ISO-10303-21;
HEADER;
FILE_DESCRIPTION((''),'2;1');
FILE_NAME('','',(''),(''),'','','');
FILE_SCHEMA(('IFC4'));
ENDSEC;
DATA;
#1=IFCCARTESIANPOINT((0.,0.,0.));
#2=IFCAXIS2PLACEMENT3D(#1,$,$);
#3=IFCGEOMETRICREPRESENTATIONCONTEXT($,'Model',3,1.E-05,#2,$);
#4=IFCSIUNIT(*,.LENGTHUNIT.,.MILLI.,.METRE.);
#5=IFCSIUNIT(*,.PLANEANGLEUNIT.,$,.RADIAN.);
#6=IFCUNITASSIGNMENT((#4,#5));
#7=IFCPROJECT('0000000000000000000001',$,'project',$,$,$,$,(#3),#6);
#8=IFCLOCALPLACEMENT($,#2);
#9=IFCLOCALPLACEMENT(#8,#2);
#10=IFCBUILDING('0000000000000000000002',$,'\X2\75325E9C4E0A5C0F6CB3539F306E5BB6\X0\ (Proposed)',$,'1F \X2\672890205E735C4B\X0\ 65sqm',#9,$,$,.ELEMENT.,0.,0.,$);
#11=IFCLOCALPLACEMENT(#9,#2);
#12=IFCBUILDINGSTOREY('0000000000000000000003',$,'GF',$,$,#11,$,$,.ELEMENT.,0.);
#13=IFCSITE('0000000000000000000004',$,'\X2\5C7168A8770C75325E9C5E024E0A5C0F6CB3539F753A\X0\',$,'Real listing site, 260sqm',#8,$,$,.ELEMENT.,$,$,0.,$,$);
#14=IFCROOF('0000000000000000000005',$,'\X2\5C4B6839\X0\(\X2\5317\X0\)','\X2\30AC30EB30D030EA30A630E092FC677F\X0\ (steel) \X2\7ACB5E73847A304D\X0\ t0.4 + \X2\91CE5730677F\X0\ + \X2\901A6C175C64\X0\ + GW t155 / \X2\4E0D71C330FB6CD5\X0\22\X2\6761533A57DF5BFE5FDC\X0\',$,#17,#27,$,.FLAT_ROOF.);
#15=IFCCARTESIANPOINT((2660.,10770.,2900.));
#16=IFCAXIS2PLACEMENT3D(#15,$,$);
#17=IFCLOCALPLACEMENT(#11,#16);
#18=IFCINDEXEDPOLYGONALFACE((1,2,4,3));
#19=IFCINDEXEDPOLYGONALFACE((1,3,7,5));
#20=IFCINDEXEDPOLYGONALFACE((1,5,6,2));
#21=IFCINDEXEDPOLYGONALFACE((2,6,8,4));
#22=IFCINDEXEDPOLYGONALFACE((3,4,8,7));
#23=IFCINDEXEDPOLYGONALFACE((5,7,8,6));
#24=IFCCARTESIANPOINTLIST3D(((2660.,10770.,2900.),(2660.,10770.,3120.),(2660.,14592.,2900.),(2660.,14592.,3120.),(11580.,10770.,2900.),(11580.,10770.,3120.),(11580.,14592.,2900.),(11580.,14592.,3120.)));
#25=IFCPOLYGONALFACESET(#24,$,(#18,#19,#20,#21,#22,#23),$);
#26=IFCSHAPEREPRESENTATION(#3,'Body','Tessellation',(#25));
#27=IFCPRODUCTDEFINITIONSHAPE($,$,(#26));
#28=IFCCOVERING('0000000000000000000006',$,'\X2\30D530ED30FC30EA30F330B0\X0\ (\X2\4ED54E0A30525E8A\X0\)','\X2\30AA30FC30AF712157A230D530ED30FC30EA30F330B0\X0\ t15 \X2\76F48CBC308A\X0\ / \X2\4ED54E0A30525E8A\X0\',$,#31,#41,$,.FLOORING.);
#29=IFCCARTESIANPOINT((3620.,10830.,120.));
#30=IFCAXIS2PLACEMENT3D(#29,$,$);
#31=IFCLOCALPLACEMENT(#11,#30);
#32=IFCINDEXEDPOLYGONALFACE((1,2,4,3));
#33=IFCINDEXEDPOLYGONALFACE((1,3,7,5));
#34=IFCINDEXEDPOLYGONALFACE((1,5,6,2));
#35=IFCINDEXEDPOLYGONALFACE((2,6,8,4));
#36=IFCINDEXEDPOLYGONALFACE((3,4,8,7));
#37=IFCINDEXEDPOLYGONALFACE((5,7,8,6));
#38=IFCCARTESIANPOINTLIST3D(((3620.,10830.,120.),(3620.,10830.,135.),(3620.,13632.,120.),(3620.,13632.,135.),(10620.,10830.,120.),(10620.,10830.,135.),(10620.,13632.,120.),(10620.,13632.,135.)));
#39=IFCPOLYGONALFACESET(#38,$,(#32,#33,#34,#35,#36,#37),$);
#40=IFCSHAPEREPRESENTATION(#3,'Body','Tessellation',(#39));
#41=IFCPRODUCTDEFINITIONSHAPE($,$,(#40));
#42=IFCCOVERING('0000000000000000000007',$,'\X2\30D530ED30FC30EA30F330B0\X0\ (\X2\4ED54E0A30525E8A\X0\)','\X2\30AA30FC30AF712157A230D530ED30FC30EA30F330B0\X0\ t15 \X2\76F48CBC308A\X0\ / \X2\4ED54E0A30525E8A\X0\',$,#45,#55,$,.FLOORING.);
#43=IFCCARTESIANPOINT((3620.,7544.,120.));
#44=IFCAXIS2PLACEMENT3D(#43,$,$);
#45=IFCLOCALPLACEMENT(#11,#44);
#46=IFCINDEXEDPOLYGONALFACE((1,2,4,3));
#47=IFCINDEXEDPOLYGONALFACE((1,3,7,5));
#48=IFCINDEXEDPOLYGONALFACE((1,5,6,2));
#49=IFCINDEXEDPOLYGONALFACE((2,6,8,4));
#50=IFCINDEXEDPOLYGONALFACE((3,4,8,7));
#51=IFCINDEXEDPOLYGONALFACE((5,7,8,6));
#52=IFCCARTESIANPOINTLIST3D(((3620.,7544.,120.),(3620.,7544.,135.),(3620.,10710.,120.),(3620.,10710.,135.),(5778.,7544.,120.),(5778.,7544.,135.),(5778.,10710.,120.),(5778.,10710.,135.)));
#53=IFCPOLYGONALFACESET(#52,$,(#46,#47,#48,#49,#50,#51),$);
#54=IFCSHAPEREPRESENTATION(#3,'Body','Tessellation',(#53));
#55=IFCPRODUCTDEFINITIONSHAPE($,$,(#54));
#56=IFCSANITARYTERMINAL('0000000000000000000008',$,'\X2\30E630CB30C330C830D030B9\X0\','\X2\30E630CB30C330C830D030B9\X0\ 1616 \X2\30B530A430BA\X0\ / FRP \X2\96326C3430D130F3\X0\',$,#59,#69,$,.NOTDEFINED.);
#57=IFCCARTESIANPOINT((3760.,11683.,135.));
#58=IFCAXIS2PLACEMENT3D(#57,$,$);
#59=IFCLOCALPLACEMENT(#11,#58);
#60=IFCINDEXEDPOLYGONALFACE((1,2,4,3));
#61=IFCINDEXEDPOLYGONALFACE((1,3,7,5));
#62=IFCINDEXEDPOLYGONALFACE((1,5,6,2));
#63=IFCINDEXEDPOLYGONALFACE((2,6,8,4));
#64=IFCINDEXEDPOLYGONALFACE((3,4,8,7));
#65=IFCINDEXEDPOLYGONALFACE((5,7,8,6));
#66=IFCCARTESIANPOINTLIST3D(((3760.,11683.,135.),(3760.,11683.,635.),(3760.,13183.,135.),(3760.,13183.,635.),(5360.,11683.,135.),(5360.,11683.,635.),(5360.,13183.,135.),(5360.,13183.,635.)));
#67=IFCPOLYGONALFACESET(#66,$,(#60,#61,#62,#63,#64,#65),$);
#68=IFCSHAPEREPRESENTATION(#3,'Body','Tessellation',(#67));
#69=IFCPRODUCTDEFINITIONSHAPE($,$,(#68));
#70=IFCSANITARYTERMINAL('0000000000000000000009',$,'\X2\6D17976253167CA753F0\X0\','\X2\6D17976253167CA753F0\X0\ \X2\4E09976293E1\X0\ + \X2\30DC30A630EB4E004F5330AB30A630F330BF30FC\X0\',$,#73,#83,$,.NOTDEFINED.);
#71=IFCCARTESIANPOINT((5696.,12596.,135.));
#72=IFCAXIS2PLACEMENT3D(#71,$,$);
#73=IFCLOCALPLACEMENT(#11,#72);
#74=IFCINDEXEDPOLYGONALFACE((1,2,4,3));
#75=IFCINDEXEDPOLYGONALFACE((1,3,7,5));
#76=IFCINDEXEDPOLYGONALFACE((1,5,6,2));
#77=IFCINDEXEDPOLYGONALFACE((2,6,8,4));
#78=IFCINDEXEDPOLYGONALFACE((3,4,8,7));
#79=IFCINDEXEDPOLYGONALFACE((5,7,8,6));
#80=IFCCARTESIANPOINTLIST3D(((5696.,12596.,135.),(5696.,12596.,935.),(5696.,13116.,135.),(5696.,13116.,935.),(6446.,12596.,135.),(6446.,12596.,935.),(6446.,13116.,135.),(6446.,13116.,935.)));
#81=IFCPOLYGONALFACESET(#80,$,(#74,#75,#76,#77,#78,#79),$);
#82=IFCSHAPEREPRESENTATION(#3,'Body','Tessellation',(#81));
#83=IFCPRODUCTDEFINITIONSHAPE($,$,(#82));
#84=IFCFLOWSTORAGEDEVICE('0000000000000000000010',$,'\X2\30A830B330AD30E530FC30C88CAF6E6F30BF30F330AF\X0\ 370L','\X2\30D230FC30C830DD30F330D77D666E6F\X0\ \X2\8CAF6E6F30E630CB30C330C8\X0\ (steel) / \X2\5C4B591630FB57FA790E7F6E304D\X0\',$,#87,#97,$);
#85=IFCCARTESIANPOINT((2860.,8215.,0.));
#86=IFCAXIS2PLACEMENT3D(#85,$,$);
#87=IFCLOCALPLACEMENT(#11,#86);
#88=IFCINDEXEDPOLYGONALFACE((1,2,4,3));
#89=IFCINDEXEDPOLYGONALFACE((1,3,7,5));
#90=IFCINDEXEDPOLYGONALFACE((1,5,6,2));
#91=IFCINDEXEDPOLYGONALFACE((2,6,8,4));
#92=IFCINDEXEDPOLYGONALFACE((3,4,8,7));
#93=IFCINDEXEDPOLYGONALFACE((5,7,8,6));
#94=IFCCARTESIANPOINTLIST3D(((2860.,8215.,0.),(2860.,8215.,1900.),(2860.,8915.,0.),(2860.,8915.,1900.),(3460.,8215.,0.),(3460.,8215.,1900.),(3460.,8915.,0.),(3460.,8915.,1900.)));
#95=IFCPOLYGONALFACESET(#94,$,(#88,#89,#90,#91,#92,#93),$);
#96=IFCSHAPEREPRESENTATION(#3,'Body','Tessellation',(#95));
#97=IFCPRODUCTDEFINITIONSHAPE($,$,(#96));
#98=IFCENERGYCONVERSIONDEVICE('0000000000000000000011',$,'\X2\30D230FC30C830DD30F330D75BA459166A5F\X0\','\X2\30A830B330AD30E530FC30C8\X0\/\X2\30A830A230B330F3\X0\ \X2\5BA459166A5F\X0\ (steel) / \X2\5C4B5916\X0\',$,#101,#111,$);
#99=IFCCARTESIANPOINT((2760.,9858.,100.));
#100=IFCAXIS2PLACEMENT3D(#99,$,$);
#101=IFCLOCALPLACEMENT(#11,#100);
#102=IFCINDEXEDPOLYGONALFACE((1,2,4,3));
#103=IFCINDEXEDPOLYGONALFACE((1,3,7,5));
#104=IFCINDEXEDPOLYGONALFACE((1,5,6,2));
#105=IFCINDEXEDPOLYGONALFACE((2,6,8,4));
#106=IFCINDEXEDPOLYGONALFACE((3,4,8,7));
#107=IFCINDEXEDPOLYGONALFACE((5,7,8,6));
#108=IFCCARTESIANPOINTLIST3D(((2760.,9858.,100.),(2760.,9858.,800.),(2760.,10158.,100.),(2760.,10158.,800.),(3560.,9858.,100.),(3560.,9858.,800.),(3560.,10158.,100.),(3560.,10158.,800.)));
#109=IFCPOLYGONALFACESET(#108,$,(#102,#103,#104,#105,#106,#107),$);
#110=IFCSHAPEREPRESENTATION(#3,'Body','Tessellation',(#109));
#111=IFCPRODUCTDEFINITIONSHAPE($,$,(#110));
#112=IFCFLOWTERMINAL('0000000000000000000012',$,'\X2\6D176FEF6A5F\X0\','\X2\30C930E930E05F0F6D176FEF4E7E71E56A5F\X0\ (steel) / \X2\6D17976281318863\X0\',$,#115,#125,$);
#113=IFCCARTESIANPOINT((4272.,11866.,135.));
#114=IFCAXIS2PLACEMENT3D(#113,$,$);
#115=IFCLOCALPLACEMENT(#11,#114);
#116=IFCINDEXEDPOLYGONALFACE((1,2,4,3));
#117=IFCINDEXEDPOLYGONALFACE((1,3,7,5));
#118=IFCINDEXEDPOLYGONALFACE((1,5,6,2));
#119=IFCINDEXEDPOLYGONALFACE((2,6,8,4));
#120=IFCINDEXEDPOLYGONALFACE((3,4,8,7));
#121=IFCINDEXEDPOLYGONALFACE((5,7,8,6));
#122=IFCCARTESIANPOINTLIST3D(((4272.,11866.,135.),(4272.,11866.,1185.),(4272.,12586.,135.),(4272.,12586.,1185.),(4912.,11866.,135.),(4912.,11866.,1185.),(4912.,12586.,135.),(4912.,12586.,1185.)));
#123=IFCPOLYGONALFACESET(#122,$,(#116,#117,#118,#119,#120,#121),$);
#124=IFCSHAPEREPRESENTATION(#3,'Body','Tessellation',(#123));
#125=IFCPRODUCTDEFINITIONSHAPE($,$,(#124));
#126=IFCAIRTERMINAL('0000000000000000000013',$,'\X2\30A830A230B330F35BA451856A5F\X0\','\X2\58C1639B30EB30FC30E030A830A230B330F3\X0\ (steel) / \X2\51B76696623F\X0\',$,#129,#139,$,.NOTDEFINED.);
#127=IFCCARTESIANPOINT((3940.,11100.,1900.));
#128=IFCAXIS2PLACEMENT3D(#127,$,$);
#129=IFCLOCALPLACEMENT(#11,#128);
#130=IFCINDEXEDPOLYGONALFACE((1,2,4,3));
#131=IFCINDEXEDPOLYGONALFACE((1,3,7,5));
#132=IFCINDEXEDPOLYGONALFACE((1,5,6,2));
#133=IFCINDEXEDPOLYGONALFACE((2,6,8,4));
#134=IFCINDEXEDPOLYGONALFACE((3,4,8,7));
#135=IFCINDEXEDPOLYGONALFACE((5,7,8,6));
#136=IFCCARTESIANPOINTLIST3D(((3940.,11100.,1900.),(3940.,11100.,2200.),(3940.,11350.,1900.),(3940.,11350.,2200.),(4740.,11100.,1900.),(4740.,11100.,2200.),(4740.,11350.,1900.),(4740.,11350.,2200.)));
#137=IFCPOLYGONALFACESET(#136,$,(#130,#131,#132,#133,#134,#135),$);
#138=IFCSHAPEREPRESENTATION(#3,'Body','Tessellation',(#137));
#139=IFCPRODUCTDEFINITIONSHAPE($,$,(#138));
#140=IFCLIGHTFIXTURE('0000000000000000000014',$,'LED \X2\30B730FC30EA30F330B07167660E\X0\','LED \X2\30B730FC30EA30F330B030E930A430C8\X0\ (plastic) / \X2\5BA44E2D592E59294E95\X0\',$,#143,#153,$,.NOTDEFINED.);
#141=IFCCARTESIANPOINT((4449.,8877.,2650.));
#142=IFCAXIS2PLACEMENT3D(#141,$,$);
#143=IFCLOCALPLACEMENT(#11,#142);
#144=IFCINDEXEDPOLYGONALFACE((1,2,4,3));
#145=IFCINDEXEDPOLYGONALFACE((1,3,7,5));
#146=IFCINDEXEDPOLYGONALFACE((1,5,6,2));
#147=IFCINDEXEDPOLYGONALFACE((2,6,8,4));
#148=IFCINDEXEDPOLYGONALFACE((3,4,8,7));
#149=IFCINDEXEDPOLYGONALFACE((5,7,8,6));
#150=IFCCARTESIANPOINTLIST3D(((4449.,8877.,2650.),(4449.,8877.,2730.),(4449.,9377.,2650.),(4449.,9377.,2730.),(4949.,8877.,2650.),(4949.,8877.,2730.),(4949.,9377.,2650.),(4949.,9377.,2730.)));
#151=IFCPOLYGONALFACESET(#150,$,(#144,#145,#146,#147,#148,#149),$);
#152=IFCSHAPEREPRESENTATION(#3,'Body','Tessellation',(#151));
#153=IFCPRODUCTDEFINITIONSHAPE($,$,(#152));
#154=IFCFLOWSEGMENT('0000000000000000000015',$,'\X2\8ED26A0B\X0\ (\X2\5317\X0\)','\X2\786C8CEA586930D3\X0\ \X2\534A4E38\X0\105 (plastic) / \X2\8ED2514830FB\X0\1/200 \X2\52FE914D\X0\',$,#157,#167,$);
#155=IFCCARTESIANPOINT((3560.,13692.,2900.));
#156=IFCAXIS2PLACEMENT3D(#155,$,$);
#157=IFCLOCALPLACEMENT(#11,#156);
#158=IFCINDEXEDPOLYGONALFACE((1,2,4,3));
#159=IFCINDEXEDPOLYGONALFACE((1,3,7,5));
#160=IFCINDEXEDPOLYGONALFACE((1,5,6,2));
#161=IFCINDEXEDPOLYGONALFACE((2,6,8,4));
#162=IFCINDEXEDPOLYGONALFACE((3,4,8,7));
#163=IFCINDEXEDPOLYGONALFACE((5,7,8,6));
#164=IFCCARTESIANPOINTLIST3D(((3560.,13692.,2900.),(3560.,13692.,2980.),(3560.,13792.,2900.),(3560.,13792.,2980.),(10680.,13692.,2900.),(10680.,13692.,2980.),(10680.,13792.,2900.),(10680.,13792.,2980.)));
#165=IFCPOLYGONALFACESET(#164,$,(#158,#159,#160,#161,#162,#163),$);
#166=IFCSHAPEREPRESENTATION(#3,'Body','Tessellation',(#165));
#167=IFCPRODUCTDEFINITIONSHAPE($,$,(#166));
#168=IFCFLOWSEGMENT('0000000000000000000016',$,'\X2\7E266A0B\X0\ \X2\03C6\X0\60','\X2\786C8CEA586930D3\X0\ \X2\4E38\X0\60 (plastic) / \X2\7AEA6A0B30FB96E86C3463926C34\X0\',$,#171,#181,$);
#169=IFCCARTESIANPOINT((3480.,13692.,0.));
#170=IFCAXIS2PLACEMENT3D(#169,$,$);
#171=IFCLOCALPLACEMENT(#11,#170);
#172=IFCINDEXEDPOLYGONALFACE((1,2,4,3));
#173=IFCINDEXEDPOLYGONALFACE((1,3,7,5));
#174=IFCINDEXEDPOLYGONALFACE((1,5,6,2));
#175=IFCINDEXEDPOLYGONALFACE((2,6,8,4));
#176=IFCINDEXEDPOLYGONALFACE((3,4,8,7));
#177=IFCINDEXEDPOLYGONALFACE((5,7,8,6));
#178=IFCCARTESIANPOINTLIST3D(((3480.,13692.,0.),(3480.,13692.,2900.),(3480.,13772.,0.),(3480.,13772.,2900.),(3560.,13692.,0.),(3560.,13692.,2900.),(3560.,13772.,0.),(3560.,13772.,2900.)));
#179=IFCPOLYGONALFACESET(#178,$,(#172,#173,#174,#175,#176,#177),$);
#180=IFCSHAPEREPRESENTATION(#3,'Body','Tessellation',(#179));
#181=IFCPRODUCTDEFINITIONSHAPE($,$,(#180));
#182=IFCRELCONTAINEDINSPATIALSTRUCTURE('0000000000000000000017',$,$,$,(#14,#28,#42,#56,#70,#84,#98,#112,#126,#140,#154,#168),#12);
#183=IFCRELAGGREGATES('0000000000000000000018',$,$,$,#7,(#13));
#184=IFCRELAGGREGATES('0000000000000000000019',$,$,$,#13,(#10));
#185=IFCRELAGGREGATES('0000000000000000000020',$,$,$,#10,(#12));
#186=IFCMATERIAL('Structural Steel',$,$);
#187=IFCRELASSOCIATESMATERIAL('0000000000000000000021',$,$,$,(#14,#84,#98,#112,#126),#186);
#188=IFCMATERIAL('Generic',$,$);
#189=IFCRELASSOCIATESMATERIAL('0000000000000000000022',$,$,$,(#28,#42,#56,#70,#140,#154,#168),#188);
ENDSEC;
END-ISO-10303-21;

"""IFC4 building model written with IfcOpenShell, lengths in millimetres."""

from ifc_helpers import new_model, si_unit, frame, frame_2d, origin, place, context, project, spatial, rectangle, extrude, material, element, save


model = new_model("IFC4")

# Units and contexts
model_context = context("Model", 3, precision=1e-05, world=origin())
ifc_project = project(units=[si_unit("LENGTHUNIT", "METRE", prefix="MILLI"), si_unit("PLANEANGLEUNIT", "RADIAN")], contexts=[model_context])

# Site, building, storey
site_placement = place(None, origin())
site = spatial("IfcSite", under=ifc_project, at=site_placement, Name="山梨県甲府市上小河原町", ObjectType="Real listing site, 260sqm", CompositionType="ELEMENT", RefElevation=0.0)
building_placement = place(site_placement, origin())
building = spatial("IfcBuilding", under=site, at=building_placement, Name="甲府上小河原の家 (Proposed)", ObjectType="1F 木造平屋 65sqm", CompositionType="ELEMENT", ElevationOfRefHeight=0.0, ElevationOfTerrain=0.0)
storey_placement = place(building_placement, origin())
storey = spatial("IfcBuildingStorey", under=building, at=storey_placement, Name="GF", CompositionType="ELEMENT", Elevation=0.0)

# Roof
ifc_material_1 = material(Name="Structural Steel")
roof_placement = place(storey_placement, frame((2660.0, 10770.0, 2900.0)))
element("IfcRoof", 1, at=roof_placement, inside=storey, material=ifc_material_1, Name="屋根(北)", Description="ガルバリウム鋼板 (steel) 立平葺き t0.4 + 野地板 + 通気層 + GW t155 / 不燃・法22条区域対応", PredefinedType="FLAT_ROOF", context=model_context, shape_type="SweptSolid", body=[
    extrude(rectangle(XDim=8920.0, YDim=3822.0, at=frame_2d((4460.0, 1911.0))), frame((2660.0, 10770.0, 2900.0)), (0.0, 0.0, 1.0), 220.0),
])

# Coverings
ifc_material_2 = material(Name="Generic")
covering_1_placement = place(storey_placement, frame((3620.0, 10830.0, 120.0)))
element("IfcCovering", 2, at=covering_1_placement, inside=storey, material=ifc_material_2, Name="フローリング (仕上げ床)", Description="オーク無垢フローリング t15 直貼り / 仕上げ床", PredefinedType="FLOORING", context=model_context, shape_type="SweptSolid", body=[
    extrude(rectangle(XDim=7000.0, YDim=2802.0, at=frame_2d((3500.0, 1401.0))), frame((3620.0, 10830.0, 120.0)), (0.0, 0.0, 1.0), 15.0),
])
covering_2_placement = place(storey_placement, frame((3620.0, 7544.0, 120.0)))
element("IfcCovering", 3, at=covering_2_placement, inside=storey, material=ifc_material_2, Name="フローリング (仕上げ床)", Description="オーク無垢フローリング t15 直貼り / 仕上げ床", PredefinedType="FLOORING", context=model_context, shape_type="SweptSolid", body=[
    extrude(rectangle(XDim=2158.0, YDim=3166.0, at=frame_2d((1079.0, 1583.0))), frame((3620.0, 7544.0, 120.0)), (0.0, 0.0, 1.0), 15.0),
])

# Sanitary terminals
sanitary_terminal_1_placement = place(storey_placement, frame((3760.0, 11683.0, 135.0)))
element("IfcSanitaryTerminal", 4, at=sanitary_terminal_1_placement, inside=storey, material=ifc_material_2, Name="ユニットバス", Description="ユニットバス 1616 サイズ / FRP 防水パン", PredefinedType="NOTDEFINED", context=model_context, shape_type="SweptSolid", body=[
    extrude(rectangle(XDim=1600.0, YDim=1500.0, at=frame_2d((800.0, 750.0))), frame((3760.0, 11683.0, 135.0)), (0.0, 0.0, 1.0), 500.0),
])
sanitary_terminal_2_placement = place(storey_placement, frame((5696.0, 12596.0, 135.0)))
element("IfcSanitaryTerminal", 5, at=sanitary_terminal_2_placement, inside=storey, material=ifc_material_2, Name="洗面化粧台", Description="洗面化粧台 三面鏡 + ボウル一体カウンター", PredefinedType="NOTDEFINED", context=model_context, shape_type="SweptSolid", body=[
    extrude(rectangle(XDim=750.0, YDim=520.0, at=frame_2d((375.0, 260.0))), frame((5696.0, 12596.0, 135.0)), (0.0, 0.0, 1.0), 800.0),
])

# Flow storage device
flow_storage_device_placement = place(storey_placement, frame((2860.0, 8215.0, 0.0)))
element("IfcFlowStorageDevice", 6, at=flow_storage_device_placement, inside=storey, material=ifc_material_1, Name="エコキュート貯湯タンク 370L", Description="ヒートポンプ給湯 貯湯ユニット (steel) / 屋外・基礎置き", context=model_context, shape_type="SweptSolid", body=[
    extrude(rectangle(XDim=600.0, YDim=700.0, at=frame_2d((300.0, 350.0))), frame((2860.0, 8215.0, 0.0)), (0.0, 0.0, 1.0), 1900.0),
])

# Energy conversion device
energy_conversion_device_placement = place(storey_placement, frame((2760.0, 9858.0, 100.0)))
element("IfcEnergyConversionDevice", 7, at=energy_conversion_device_placement, inside=storey, material=ifc_material_1, Name="ヒートポンプ室外機", Description="エコキュート/エアコン 室外機 (steel) / 屋外", context=model_context, shape_type="SweptSolid", body=[
    extrude(rectangle(XDim=800.0, YDim=300.0, at=frame_2d((400.0, 150.0))), frame((2760.0, 9858.0, 100.0)), (0.0, 0.0, 1.0), 700.0),
])

# Flow terminal
flow_terminal_placement = place(storey_placement, frame((4272.0, 11866.0, 135.0)))
element("IfcFlowTerminal", 8, at=flow_terminal_placement, inside=storey, material=ifc_material_1, Name="洗濯機", Description="ドラム式洗濯乾燥機 (steel) / 洗面脱衣", context=model_context, shape_type="SweptSolid", body=[
    extrude(rectangle(XDim=640.0, YDim=720.0, at=frame_2d((320.0, 360.0))), frame((4272.0, 11866.0, 135.0)), (0.0, 0.0, 1.0), 1050.0),
])

# Air terminal
air_terminal_placement = place(storey_placement, frame((3940.0, 11100.0, 1900.0)))
element("IfcAirTerminal", 9, at=air_terminal_placement, inside=storey, material=ifc_material_1, Name="エアコン室内機", Description="壁掛ルームエアコン (steel) / 冷暖房", PredefinedType="NOTDEFINED", context=model_context, shape_type="SweptSolid", body=[
    extrude(rectangle(XDim=800.0, YDim=250.0, at=frame_2d((400.0, 125.0))), frame((3940.0, 11100.0, 1900.0)), (0.0, 0.0, 1.0), 300.0),
])

# Light fixture
light_fixture_placement = place(storey_placement, frame((4449.0, 8877.0, 2650.0)))
element("IfcLightFixture", 10, at=light_fixture_placement, inside=storey, material=ifc_material_2, Name="LED シーリング照明", Description="LED シーリングライト (plastic) / 室中央天井", PredefinedType="NOTDEFINED", context=model_context, shape_type="SweptSolid", body=[
    extrude(rectangle(XDim=500.0, YDim=500.0, at=frame_2d((250.0, 250.0))), frame((4449.0, 8877.0, 2650.0)), (0.0, 0.0, 1.0), 80.0),
])

# Flow segments
flow_segment_1_placement = place(storey_placement, frame((3560.0, 13692.0, 2900.0)))
element("IfcFlowSegment", 11, at=flow_segment_1_placement, inside=storey, material=ifc_material_2, Name="軒樋 (北)", Description="硬質塩ビ 半丸105 (plastic) / 軒先・1/200 勾配", context=model_context, shape_type="SweptSolid", body=[
    extrude(rectangle(XDim=7120.0, YDim=100.0, at=frame_2d((3560.0, 50.0))), frame((3560.0, 13692.0, 2900.0)), (0.0, 0.0, 1.0), 80.0),
])
flow_segment_2_placement = place(storey_placement, frame((3480.0, 13692.0, 0.0)))
element("IfcFlowSegment", 12, at=flow_segment_2_placement, inside=storey, material=ifc_material_2, Name="縦樋 φ60", Description="硬質塩ビ 丸60 (plastic) / 竪樋・雨水排水", context=model_context, shape_type="SweptSolid", body=[
    extrude(rectangle(XDim=80.0, YDim=80.0, at=frame_2d((40.0, 40.0))), frame((3480.0, 13692.0, 0.0)), (0.0, 0.0, 1.0), 2900.0),
])

save(model, "model.ifc")
